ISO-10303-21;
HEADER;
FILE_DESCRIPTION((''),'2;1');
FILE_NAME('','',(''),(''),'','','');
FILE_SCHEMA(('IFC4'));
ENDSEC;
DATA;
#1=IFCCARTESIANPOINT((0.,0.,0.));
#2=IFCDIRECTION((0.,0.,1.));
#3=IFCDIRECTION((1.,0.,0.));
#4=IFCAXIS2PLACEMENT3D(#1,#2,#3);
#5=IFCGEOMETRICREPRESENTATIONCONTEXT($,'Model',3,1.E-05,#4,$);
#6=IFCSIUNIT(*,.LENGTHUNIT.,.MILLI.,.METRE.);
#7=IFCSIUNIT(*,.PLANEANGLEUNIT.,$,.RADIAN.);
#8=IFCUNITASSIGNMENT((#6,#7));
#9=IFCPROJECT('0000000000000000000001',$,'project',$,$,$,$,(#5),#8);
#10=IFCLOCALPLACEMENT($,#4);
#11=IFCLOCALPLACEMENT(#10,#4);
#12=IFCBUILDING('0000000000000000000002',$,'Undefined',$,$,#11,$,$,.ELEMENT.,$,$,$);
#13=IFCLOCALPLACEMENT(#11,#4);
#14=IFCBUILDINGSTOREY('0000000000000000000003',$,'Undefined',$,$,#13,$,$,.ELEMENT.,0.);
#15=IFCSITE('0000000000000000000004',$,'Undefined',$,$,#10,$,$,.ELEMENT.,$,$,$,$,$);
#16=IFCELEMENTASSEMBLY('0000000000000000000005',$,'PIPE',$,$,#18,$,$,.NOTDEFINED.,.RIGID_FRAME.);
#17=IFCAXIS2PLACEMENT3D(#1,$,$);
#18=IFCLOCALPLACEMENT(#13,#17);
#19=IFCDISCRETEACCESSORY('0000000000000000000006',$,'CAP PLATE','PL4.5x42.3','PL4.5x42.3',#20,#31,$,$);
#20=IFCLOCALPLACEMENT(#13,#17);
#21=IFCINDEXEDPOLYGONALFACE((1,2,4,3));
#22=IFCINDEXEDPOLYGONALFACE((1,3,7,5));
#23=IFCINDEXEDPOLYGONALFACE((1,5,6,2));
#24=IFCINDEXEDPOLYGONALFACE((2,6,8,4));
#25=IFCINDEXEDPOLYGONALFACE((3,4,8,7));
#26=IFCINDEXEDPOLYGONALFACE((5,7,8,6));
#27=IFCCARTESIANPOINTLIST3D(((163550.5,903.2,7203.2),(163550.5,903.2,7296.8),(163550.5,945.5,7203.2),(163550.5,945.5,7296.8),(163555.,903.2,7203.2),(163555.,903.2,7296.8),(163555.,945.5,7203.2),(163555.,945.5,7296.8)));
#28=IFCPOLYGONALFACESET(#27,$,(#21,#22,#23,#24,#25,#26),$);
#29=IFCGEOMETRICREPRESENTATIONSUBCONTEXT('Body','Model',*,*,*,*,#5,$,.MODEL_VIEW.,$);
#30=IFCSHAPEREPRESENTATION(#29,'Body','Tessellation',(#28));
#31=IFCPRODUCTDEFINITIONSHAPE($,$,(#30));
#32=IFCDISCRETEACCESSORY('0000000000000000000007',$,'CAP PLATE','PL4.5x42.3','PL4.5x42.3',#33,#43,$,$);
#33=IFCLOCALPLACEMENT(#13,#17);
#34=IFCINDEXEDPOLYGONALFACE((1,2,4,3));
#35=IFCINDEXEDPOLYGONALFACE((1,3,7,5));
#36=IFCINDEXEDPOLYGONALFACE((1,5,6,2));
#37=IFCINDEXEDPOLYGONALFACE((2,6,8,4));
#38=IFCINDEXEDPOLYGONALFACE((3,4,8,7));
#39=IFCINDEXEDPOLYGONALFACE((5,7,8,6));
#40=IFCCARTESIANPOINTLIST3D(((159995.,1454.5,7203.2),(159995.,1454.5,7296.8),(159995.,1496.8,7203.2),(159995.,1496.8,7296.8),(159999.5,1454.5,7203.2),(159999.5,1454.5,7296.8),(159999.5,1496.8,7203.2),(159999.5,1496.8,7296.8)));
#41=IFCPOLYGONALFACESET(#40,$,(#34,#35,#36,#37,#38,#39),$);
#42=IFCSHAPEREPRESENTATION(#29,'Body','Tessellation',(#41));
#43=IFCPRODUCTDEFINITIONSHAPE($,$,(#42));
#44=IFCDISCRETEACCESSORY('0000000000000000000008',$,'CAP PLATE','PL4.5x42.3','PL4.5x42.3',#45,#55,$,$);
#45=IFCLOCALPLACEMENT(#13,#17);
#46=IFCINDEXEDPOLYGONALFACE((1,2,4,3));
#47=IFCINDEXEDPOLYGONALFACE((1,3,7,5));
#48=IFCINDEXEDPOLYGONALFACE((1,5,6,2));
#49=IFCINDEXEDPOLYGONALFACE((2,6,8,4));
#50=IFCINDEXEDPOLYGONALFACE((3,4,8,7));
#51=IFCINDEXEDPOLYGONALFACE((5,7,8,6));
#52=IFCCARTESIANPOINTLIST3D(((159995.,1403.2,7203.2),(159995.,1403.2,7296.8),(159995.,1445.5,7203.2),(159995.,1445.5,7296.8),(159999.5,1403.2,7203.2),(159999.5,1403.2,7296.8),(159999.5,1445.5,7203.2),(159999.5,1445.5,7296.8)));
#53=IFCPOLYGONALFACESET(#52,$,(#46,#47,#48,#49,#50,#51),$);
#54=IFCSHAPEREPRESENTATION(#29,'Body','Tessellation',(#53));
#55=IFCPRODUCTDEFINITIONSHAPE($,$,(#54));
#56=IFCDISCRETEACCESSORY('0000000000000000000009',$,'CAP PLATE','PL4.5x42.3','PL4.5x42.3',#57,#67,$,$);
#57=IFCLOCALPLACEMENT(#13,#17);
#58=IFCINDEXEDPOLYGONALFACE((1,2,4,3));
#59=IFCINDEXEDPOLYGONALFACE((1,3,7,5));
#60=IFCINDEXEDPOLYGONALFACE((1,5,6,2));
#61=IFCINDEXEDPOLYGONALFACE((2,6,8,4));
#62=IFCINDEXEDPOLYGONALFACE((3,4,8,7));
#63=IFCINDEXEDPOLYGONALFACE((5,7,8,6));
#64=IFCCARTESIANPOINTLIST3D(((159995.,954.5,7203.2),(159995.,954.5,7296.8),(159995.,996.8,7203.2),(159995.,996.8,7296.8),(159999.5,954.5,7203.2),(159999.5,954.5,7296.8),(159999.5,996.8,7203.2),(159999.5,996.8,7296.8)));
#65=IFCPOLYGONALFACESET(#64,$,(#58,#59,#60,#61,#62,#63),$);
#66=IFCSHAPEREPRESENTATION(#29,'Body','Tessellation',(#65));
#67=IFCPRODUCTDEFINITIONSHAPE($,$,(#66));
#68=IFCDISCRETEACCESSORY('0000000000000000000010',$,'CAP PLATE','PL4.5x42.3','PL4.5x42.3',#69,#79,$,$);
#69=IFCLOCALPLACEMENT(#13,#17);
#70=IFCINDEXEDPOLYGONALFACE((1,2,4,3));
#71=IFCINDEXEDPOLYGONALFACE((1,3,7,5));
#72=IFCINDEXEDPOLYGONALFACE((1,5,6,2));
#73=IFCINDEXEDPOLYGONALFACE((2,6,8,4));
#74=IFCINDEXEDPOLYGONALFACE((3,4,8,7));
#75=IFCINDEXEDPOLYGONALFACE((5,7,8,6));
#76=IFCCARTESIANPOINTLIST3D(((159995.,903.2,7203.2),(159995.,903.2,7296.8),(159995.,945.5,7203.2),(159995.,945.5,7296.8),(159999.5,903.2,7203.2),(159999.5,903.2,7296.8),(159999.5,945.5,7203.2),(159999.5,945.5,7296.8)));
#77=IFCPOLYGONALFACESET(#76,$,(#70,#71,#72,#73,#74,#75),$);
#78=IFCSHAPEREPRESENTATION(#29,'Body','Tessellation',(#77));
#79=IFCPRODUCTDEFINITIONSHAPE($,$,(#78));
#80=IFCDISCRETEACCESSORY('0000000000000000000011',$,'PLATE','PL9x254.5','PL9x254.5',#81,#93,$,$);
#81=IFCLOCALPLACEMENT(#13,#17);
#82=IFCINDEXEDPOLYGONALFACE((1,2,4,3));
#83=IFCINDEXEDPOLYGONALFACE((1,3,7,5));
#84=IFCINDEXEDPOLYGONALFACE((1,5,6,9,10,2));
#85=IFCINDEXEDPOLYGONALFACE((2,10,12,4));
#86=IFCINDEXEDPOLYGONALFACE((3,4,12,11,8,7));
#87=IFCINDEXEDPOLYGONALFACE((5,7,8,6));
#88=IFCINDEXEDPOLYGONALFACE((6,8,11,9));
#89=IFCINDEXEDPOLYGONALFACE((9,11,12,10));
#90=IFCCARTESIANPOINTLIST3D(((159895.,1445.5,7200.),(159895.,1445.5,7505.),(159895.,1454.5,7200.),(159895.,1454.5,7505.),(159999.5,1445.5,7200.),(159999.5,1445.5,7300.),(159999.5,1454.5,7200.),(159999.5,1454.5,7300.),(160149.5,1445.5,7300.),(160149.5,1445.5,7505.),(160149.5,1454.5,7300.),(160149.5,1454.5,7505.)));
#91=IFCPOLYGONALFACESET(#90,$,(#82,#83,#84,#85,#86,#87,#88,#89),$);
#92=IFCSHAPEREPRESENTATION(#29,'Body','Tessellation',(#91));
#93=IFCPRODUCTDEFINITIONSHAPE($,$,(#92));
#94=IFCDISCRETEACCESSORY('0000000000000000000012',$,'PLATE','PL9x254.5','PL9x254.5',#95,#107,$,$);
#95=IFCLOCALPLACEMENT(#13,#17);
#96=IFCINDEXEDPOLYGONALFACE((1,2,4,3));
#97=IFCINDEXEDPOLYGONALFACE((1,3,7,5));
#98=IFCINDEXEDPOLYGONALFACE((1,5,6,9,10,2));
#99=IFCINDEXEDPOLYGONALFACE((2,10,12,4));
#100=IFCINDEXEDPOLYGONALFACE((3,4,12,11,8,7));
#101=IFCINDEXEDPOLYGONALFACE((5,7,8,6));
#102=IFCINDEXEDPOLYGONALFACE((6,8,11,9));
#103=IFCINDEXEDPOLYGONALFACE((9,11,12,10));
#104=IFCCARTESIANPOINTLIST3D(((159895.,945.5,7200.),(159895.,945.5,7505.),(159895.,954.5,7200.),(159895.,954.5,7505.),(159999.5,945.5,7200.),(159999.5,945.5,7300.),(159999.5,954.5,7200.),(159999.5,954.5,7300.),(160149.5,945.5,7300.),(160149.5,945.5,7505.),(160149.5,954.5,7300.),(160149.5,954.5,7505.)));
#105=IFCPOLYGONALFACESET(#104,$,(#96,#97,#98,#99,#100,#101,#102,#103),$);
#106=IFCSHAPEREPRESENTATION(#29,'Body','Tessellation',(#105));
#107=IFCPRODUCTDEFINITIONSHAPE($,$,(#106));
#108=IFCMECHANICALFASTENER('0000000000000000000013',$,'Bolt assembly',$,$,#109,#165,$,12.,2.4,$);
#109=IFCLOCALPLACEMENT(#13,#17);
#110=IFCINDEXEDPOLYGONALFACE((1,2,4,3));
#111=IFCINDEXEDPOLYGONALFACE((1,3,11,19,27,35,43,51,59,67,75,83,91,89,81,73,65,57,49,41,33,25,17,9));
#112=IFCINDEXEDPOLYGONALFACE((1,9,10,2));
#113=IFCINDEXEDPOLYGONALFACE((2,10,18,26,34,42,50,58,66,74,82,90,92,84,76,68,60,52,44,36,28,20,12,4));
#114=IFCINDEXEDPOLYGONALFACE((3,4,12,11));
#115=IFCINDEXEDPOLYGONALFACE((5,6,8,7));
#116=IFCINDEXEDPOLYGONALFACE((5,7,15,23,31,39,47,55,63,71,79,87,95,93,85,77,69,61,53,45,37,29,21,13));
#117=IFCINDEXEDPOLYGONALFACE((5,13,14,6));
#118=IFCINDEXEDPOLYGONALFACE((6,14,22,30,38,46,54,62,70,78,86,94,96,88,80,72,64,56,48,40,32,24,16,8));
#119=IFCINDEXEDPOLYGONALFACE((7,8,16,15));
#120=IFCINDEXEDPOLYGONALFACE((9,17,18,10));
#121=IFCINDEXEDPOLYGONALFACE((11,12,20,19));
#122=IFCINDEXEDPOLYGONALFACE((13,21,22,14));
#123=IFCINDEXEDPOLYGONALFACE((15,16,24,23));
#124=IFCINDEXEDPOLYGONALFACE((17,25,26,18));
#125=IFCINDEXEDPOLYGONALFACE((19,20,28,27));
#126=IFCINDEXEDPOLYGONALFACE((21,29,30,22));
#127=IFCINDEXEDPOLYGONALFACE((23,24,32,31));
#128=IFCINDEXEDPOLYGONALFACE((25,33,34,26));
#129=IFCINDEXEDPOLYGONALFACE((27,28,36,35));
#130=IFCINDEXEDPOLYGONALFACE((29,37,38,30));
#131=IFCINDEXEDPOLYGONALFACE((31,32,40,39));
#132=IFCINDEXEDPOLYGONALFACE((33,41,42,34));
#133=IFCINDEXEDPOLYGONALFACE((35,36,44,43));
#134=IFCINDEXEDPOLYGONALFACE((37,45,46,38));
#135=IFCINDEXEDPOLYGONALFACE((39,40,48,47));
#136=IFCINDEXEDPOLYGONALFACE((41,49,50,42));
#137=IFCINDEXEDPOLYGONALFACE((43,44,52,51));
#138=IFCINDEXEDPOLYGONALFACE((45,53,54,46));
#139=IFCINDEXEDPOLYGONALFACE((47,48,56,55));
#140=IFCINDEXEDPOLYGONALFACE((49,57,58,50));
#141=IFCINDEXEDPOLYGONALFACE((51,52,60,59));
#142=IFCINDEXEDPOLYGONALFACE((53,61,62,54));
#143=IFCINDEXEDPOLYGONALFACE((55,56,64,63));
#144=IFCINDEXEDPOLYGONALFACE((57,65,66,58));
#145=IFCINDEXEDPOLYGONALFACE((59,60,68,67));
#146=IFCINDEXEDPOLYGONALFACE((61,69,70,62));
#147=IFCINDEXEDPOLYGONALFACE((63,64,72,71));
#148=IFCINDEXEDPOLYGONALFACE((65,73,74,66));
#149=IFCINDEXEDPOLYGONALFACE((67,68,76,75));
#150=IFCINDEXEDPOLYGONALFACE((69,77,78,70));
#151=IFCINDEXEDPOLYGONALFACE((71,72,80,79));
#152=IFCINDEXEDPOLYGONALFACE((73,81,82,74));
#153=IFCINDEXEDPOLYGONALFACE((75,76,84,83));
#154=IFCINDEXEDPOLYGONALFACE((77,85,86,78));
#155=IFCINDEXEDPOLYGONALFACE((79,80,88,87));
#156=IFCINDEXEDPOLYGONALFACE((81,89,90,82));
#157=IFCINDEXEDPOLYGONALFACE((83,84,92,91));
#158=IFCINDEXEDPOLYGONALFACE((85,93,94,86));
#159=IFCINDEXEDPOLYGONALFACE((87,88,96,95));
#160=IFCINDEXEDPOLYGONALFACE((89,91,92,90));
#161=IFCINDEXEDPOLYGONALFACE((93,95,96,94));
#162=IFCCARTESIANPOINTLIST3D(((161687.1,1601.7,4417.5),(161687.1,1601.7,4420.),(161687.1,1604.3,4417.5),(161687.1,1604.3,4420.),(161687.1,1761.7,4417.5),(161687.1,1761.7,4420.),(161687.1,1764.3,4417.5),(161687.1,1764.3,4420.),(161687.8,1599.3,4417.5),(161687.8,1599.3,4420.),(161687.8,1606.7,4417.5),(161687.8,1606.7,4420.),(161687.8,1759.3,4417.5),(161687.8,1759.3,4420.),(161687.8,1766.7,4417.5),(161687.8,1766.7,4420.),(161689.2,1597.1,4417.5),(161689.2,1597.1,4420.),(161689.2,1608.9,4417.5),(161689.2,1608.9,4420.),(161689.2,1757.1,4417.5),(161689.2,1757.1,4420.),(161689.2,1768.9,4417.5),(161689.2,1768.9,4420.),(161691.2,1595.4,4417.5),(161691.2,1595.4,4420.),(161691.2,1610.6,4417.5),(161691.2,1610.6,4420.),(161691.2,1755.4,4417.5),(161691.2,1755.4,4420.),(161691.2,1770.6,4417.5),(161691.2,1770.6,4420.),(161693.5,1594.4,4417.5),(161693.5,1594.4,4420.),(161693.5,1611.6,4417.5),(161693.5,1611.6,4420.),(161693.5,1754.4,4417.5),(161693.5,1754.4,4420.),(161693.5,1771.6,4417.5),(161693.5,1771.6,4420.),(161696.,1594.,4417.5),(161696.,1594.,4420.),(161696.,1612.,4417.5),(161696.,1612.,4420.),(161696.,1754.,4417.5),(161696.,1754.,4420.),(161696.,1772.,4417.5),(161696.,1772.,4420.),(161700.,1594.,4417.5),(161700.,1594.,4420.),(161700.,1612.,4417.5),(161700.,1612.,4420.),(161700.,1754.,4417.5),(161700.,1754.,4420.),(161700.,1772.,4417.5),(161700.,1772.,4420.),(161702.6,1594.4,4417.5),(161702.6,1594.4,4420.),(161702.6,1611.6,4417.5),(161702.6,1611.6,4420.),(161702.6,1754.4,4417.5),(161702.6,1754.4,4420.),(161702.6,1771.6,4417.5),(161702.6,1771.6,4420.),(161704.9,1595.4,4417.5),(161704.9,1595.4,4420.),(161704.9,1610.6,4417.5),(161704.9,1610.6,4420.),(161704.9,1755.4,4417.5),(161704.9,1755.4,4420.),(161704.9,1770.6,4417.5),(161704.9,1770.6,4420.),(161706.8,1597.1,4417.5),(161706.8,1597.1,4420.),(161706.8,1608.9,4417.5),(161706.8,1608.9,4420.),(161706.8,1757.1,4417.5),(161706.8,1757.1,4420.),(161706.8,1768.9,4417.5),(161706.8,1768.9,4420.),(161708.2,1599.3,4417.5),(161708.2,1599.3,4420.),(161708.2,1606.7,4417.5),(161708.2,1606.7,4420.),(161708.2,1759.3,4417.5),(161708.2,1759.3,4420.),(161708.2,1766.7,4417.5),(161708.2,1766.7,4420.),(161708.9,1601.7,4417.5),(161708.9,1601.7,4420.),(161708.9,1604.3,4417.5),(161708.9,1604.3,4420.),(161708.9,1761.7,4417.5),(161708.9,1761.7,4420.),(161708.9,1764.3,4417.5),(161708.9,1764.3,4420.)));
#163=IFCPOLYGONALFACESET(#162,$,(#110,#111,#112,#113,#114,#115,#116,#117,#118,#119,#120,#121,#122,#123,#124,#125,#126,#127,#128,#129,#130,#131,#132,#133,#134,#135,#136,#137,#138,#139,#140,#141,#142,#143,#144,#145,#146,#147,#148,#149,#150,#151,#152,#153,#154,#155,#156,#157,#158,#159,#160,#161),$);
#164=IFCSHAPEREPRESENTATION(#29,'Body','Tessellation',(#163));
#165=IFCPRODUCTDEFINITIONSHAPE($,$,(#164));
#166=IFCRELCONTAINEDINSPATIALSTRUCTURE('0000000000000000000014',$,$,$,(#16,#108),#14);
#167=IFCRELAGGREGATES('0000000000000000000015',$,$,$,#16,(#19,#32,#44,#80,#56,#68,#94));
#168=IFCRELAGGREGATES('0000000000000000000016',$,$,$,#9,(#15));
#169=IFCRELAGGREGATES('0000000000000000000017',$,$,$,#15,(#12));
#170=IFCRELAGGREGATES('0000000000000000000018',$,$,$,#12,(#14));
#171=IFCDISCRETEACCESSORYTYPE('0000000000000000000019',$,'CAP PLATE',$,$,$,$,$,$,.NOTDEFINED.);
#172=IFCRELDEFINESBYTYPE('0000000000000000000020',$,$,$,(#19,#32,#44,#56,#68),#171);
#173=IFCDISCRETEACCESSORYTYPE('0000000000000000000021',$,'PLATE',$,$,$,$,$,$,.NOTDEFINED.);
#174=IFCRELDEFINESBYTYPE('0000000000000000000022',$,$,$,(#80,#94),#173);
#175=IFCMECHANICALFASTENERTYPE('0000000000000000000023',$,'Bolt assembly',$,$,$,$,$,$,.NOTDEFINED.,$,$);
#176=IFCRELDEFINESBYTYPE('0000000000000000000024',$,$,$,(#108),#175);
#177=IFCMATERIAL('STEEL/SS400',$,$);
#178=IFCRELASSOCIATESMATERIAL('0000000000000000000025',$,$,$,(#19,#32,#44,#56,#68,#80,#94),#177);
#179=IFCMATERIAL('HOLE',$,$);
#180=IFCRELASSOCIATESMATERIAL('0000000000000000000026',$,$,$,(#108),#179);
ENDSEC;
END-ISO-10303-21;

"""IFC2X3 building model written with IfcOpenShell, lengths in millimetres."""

from ifc_helpers import new_model, si_unit, frame, frame_2d, origin_with_axes, place, context, subcontext, project, spatial, polyline, circle_curve, parameter, trimmed, segment, composite_curve, outline, extrude, source, transform, mapped, material, type_object, element, aggregate, save


model = new_model("IFC2X3")

# Units and contexts
model_context = context("Model", 3, precision=1e-05, world=origin_with_axes())
body_context = subcontext(model_context, "Body", "Model", "MODEL_VIEW")
ifc_project = project(units=[si_unit("LENGTHUNIT", "METRE", prefix="MILLI"), si_unit("PLANEANGLEUNIT", "RADIAN")], contexts=[model_context])

# Site, building, storey
site_placement = place(None, origin_with_axes())
site = spatial("IfcSite", under=ifc_project, at=site_placement, Name="Undefined", CompositionType="ELEMENT")
building_placement = place(site_placement, origin_with_axes())
building = spatial("IfcBuilding", under=site, at=building_placement, Name="Undefined", CompositionType="ELEMENT")
storey_placement = place(building_placement, origin_with_axes())
storey = spatial("IfcBuildingStorey", under=building, at=storey_placement, Name="Undefined", CompositionType="ELEMENT", Elevation=0.0)

# Element assembly
assembly_1_placement = place(storey_placement, origin_with_axes())
assembly_1 = element("IfcElementAssembly", 1, at=assembly_1_placement, inside=storey, Name="PIPE", AssemblyPlace="NOTDEFINED", PredefinedType="RIGID_FRAME")
ifc_material_1 = material(Name="STEEL/SS400")

# Discrete accessories
discrete_accessory_type_1 = type_object("IfcDiscreteAccessoryType", Name="CAP PLATE")
discrete_accessory_1_placement = place(assembly_1_placement, frame((163552.8, 945.5, 7203.2), z_axis=(1.0, 0.0, 0.0), x_axis=(0.0, 0.0, 1.0)))
discrete_accessory_1 = element("IfcDiscreteAccessory", 2, at=discrete_accessory_1_placement, type_object=discrete_accessory_type_1, material=ifc_material_1, Name="CAP PLATE", Description="PL4.5x42.3", ObjectType="PL4.5x42.3", context=body_context, shape_type="SweptSolid", body=[
    extrude(outline(polyline([(0.0, 0.0), (93.6, 0.0), (93.6, 42.3), (0.0, 42.3), (0.0, 0.0)])), frame((0.0, 0.0, -2.2), z_axis=(0.0, 0.0, 1.0), x_axis=(1.0, 0.0, 0.0)), (0.0, 0.0, 1.0), 4.5),
])
discrete_accessory_2_placement = place(assembly_1_placement, frame((159997.2, 1496.8, 7203.2), z_axis=(1.0, 0.0, 0.0), x_axis=(0.0, 0.0, 1.0)))
discrete_accessory_2 = element("IfcDiscreteAccessory", 3, at=discrete_accessory_2_placement, type_object=discrete_accessory_type_1, material=ifc_material_1, Name="CAP PLATE", Description="PL4.5x42.3", ObjectType="PL4.5x42.3", context=body_context, shape_type="SweptSolid", body=[
    extrude(outline(polyline([(0.0, 0.0), (93.6, 0.0), (93.6, 42.3), (0.0, 42.3), (0.0, 0.0)])), frame((0.0, 0.0, -2.2), z_axis=(0.0, 0.0, 1.0), x_axis=(1.0, 0.0, 0.0)), (0.0, 0.0, 1.0), 4.5),
])
discrete_accessory_3_placement = place(assembly_1_placement, frame((159997.2, 1445.5, 7203.2), z_axis=(1.0, 0.0, 0.0), x_axis=(0.0, 0.0, 1.0)))
discrete_accessory_3 = element("IfcDiscreteAccessory", 4, at=discrete_accessory_3_placement, type_object=discrete_accessory_type_1, material=ifc_material_1, Name="CAP PLATE", Description="PL4.5x42.3", ObjectType="PL4.5x42.3", context=body_context, shape_type="SweptSolid", body=[
    extrude(outline(polyline([(0.0, 0.0), (93.6, 0.0), (93.6, 42.3), (0.0, 42.3), (0.0, 0.0)])), frame((0.0, 0.0, -2.2), z_axis=(0.0, 0.0, 1.0), x_axis=(1.0, 0.0, 0.0)), (0.0, 0.0, 1.0), 4.5),
])
discrete_accessory_4_placement = place(assembly_1_placement, frame((159997.2, 996.8, 7203.2), z_axis=(1.0, 0.0, 0.0), x_axis=(0.0, 0.0, 1.0)))
discrete_accessory_4 = element("IfcDiscreteAccessory", 5, at=discrete_accessory_4_placement, type_object=discrete_accessory_type_1, material=ifc_material_1, Name="CAP PLATE", Description="PL4.5x42.3", ObjectType="PL4.5x42.3", context=body_context, shape_type="SweptSolid", body=[
    extrude(outline(polyline([(0.0, 0.0), (93.6, 0.0), (93.6, 42.3), (0.0, 42.3), (0.0, 0.0)])), frame((0.0, 0.0, -2.2), z_axis=(0.0, 0.0, 1.0), x_axis=(1.0, 0.0, 0.0)), (0.0, 0.0, 1.0), 4.5),
])
discrete_accessory_5_placement = place(assembly_1_placement, frame((159997.2, 945.5, 7203.2), z_axis=(1.0, 0.0, 0.0), x_axis=(0.0, 0.0, 1.0)))
discrete_accessory_5 = element("IfcDiscreteAccessory", 6, at=discrete_accessory_5_placement, type_object=discrete_accessory_type_1, material=ifc_material_1, Name="CAP PLATE", Description="PL4.5x42.3", ObjectType="PL4.5x42.3", context=body_context, shape_type="SweptSolid", body=[
    extrude(outline(polyline([(0.0, 0.0), (93.6, 0.0), (93.6, 42.3), (0.0, 42.3), (0.0, 0.0)])), frame((0.0, 0.0, -2.2), z_axis=(0.0, 0.0, 1.0), x_axis=(1.0, 0.0, 0.0)), (0.0, 0.0, 1.0), 4.5),
])
discrete_accessory_type_2 = type_object("IfcDiscreteAccessoryType", Name="PLATE")
discrete_accessory_6_placement = place(assembly_1_placement, frame((159895.0, 1450.0, 7200.0), z_axis=(0.0, 1.0, 0.0), x_axis=(0.0, 0.0, 1.0)))
discrete_accessory_6 = element("IfcDiscreteAccessory", 7, at=discrete_accessory_6_placement, type_object=discrete_accessory_type_2, material=ifc_material_1, Name="PLATE", Description="PL9x254.5", ObjectType="PL9x254.5", context=body_context, shape_type="SweptSolid", body=[
    extrude(outline(polyline([(0.0, 0.0), (305.0, 0.0), (305.0, 254.5), (100.0, 254.5), (100.0, 104.5), (0.0, 104.5), (0.0, 0.0)])), frame((0.0, 0.0, -4.5), z_axis=(0.0, 0.0, 1.0), x_axis=(1.0, 0.0, 0.0)), (0.0, 0.0, 1.0), 9.0),
])
discrete_accessory_7_placement = place(assembly_1_placement, frame((159895.0, 950.0, 7200.0), z_axis=(0.0, 1.0, 0.0), x_axis=(0.0, 0.0, 1.0)))
discrete_accessory_7 = element("IfcDiscreteAccessory", 8, at=discrete_accessory_7_placement, type_object=discrete_accessory_type_2, material=ifc_material_1, Name="PLATE", Description="PL9x254.5", ObjectType="PL9x254.5", context=body_context, shape_type="SweptSolid", body=[
    extrude(outline(polyline([(0.0, 0.0), (305.0, 0.0), (305.0, 254.5), (100.0, 254.5), (100.0, 104.5), (0.0, 104.5), (0.0, 0.0)])), frame((0.0, 0.0, -4.5), z_axis=(0.0, 0.0, 1.0), x_axis=(1.0, 0.0, 0.0)), (0.0, 0.0, 1.0), 9.0),
])
aggregate(assembly_1, [discrete_accessory_1, discrete_accessory_2, discrete_accessory_3, discrete_accessory_6, discrete_accessory_4, discrete_accessory_5, discrete_accessory_7])

# Mechanical fastener
ifc_material_2 = material(Name="HOLE")
mechanical_fastener_type = type_object("IfcMechanicalFastenerType", Name="Bolt assembly")
shared_shape_1 = source(origin_with_axes(), body_context, "Body", "SweptSolid", [
    extrude(outline(composite_curve([segment(polyline([(-2.0, 9.0), (2.0, 9.0)]), True, "CONTINUOUS"), segment(trimmed(circle_curve(frame_2d((2.0, 0.0), x_axis=(0.0, 1.0)), 9.0), [parameter(0.0)], [parameter(3.141593)], False, "PARAMETER"), True, "CONTINUOUS"), segment(polyline([(2.0, -9.0), (-2.0, -9.0)]), True, "CONTINUOUS"), segment(trimmed(circle_curve(frame_2d((-2.0, 0.0), x_axis=(0.0, -1.0)), 9.0), [parameter(0.0)], [parameter(3.141593)], False, "PARAMETER"), True, "DISCONTINUOUS")], self_intersect=False)), frame((0.0, -2.4, 0.0), z_axis=(0.0, 1.0, 0.0), x_axis=(1.0, 0.0, 0.0)), (0.0, 0.0, 1.0), 2.5),
])
mechanical_fastener_1_placement = place(storey_placement, frame((161698.0, 1683.0, 4417.6), z_axis=(0.0, -1.0, 0.0), x_axis=(-1.0, 0.0, 0.0)))
element("IfcMechanicalFastener", 9, at=mechanical_fastener_1_placement, inside=storey, type_object=mechanical_fastener_type, material=ifc_material_2, Name="Bolt assembly", NominalDiameter=12.0, NominalLength=2.4, context=body_context, shape_type="MappedRepresentation", body=[
    mapped(shared_shape_1, transform((0.0, 0.0, -80.0))),
    mapped(shared_shape_1, transform((0.0, 0.0, 80.0))),
])

save(model, "model.ifc")
